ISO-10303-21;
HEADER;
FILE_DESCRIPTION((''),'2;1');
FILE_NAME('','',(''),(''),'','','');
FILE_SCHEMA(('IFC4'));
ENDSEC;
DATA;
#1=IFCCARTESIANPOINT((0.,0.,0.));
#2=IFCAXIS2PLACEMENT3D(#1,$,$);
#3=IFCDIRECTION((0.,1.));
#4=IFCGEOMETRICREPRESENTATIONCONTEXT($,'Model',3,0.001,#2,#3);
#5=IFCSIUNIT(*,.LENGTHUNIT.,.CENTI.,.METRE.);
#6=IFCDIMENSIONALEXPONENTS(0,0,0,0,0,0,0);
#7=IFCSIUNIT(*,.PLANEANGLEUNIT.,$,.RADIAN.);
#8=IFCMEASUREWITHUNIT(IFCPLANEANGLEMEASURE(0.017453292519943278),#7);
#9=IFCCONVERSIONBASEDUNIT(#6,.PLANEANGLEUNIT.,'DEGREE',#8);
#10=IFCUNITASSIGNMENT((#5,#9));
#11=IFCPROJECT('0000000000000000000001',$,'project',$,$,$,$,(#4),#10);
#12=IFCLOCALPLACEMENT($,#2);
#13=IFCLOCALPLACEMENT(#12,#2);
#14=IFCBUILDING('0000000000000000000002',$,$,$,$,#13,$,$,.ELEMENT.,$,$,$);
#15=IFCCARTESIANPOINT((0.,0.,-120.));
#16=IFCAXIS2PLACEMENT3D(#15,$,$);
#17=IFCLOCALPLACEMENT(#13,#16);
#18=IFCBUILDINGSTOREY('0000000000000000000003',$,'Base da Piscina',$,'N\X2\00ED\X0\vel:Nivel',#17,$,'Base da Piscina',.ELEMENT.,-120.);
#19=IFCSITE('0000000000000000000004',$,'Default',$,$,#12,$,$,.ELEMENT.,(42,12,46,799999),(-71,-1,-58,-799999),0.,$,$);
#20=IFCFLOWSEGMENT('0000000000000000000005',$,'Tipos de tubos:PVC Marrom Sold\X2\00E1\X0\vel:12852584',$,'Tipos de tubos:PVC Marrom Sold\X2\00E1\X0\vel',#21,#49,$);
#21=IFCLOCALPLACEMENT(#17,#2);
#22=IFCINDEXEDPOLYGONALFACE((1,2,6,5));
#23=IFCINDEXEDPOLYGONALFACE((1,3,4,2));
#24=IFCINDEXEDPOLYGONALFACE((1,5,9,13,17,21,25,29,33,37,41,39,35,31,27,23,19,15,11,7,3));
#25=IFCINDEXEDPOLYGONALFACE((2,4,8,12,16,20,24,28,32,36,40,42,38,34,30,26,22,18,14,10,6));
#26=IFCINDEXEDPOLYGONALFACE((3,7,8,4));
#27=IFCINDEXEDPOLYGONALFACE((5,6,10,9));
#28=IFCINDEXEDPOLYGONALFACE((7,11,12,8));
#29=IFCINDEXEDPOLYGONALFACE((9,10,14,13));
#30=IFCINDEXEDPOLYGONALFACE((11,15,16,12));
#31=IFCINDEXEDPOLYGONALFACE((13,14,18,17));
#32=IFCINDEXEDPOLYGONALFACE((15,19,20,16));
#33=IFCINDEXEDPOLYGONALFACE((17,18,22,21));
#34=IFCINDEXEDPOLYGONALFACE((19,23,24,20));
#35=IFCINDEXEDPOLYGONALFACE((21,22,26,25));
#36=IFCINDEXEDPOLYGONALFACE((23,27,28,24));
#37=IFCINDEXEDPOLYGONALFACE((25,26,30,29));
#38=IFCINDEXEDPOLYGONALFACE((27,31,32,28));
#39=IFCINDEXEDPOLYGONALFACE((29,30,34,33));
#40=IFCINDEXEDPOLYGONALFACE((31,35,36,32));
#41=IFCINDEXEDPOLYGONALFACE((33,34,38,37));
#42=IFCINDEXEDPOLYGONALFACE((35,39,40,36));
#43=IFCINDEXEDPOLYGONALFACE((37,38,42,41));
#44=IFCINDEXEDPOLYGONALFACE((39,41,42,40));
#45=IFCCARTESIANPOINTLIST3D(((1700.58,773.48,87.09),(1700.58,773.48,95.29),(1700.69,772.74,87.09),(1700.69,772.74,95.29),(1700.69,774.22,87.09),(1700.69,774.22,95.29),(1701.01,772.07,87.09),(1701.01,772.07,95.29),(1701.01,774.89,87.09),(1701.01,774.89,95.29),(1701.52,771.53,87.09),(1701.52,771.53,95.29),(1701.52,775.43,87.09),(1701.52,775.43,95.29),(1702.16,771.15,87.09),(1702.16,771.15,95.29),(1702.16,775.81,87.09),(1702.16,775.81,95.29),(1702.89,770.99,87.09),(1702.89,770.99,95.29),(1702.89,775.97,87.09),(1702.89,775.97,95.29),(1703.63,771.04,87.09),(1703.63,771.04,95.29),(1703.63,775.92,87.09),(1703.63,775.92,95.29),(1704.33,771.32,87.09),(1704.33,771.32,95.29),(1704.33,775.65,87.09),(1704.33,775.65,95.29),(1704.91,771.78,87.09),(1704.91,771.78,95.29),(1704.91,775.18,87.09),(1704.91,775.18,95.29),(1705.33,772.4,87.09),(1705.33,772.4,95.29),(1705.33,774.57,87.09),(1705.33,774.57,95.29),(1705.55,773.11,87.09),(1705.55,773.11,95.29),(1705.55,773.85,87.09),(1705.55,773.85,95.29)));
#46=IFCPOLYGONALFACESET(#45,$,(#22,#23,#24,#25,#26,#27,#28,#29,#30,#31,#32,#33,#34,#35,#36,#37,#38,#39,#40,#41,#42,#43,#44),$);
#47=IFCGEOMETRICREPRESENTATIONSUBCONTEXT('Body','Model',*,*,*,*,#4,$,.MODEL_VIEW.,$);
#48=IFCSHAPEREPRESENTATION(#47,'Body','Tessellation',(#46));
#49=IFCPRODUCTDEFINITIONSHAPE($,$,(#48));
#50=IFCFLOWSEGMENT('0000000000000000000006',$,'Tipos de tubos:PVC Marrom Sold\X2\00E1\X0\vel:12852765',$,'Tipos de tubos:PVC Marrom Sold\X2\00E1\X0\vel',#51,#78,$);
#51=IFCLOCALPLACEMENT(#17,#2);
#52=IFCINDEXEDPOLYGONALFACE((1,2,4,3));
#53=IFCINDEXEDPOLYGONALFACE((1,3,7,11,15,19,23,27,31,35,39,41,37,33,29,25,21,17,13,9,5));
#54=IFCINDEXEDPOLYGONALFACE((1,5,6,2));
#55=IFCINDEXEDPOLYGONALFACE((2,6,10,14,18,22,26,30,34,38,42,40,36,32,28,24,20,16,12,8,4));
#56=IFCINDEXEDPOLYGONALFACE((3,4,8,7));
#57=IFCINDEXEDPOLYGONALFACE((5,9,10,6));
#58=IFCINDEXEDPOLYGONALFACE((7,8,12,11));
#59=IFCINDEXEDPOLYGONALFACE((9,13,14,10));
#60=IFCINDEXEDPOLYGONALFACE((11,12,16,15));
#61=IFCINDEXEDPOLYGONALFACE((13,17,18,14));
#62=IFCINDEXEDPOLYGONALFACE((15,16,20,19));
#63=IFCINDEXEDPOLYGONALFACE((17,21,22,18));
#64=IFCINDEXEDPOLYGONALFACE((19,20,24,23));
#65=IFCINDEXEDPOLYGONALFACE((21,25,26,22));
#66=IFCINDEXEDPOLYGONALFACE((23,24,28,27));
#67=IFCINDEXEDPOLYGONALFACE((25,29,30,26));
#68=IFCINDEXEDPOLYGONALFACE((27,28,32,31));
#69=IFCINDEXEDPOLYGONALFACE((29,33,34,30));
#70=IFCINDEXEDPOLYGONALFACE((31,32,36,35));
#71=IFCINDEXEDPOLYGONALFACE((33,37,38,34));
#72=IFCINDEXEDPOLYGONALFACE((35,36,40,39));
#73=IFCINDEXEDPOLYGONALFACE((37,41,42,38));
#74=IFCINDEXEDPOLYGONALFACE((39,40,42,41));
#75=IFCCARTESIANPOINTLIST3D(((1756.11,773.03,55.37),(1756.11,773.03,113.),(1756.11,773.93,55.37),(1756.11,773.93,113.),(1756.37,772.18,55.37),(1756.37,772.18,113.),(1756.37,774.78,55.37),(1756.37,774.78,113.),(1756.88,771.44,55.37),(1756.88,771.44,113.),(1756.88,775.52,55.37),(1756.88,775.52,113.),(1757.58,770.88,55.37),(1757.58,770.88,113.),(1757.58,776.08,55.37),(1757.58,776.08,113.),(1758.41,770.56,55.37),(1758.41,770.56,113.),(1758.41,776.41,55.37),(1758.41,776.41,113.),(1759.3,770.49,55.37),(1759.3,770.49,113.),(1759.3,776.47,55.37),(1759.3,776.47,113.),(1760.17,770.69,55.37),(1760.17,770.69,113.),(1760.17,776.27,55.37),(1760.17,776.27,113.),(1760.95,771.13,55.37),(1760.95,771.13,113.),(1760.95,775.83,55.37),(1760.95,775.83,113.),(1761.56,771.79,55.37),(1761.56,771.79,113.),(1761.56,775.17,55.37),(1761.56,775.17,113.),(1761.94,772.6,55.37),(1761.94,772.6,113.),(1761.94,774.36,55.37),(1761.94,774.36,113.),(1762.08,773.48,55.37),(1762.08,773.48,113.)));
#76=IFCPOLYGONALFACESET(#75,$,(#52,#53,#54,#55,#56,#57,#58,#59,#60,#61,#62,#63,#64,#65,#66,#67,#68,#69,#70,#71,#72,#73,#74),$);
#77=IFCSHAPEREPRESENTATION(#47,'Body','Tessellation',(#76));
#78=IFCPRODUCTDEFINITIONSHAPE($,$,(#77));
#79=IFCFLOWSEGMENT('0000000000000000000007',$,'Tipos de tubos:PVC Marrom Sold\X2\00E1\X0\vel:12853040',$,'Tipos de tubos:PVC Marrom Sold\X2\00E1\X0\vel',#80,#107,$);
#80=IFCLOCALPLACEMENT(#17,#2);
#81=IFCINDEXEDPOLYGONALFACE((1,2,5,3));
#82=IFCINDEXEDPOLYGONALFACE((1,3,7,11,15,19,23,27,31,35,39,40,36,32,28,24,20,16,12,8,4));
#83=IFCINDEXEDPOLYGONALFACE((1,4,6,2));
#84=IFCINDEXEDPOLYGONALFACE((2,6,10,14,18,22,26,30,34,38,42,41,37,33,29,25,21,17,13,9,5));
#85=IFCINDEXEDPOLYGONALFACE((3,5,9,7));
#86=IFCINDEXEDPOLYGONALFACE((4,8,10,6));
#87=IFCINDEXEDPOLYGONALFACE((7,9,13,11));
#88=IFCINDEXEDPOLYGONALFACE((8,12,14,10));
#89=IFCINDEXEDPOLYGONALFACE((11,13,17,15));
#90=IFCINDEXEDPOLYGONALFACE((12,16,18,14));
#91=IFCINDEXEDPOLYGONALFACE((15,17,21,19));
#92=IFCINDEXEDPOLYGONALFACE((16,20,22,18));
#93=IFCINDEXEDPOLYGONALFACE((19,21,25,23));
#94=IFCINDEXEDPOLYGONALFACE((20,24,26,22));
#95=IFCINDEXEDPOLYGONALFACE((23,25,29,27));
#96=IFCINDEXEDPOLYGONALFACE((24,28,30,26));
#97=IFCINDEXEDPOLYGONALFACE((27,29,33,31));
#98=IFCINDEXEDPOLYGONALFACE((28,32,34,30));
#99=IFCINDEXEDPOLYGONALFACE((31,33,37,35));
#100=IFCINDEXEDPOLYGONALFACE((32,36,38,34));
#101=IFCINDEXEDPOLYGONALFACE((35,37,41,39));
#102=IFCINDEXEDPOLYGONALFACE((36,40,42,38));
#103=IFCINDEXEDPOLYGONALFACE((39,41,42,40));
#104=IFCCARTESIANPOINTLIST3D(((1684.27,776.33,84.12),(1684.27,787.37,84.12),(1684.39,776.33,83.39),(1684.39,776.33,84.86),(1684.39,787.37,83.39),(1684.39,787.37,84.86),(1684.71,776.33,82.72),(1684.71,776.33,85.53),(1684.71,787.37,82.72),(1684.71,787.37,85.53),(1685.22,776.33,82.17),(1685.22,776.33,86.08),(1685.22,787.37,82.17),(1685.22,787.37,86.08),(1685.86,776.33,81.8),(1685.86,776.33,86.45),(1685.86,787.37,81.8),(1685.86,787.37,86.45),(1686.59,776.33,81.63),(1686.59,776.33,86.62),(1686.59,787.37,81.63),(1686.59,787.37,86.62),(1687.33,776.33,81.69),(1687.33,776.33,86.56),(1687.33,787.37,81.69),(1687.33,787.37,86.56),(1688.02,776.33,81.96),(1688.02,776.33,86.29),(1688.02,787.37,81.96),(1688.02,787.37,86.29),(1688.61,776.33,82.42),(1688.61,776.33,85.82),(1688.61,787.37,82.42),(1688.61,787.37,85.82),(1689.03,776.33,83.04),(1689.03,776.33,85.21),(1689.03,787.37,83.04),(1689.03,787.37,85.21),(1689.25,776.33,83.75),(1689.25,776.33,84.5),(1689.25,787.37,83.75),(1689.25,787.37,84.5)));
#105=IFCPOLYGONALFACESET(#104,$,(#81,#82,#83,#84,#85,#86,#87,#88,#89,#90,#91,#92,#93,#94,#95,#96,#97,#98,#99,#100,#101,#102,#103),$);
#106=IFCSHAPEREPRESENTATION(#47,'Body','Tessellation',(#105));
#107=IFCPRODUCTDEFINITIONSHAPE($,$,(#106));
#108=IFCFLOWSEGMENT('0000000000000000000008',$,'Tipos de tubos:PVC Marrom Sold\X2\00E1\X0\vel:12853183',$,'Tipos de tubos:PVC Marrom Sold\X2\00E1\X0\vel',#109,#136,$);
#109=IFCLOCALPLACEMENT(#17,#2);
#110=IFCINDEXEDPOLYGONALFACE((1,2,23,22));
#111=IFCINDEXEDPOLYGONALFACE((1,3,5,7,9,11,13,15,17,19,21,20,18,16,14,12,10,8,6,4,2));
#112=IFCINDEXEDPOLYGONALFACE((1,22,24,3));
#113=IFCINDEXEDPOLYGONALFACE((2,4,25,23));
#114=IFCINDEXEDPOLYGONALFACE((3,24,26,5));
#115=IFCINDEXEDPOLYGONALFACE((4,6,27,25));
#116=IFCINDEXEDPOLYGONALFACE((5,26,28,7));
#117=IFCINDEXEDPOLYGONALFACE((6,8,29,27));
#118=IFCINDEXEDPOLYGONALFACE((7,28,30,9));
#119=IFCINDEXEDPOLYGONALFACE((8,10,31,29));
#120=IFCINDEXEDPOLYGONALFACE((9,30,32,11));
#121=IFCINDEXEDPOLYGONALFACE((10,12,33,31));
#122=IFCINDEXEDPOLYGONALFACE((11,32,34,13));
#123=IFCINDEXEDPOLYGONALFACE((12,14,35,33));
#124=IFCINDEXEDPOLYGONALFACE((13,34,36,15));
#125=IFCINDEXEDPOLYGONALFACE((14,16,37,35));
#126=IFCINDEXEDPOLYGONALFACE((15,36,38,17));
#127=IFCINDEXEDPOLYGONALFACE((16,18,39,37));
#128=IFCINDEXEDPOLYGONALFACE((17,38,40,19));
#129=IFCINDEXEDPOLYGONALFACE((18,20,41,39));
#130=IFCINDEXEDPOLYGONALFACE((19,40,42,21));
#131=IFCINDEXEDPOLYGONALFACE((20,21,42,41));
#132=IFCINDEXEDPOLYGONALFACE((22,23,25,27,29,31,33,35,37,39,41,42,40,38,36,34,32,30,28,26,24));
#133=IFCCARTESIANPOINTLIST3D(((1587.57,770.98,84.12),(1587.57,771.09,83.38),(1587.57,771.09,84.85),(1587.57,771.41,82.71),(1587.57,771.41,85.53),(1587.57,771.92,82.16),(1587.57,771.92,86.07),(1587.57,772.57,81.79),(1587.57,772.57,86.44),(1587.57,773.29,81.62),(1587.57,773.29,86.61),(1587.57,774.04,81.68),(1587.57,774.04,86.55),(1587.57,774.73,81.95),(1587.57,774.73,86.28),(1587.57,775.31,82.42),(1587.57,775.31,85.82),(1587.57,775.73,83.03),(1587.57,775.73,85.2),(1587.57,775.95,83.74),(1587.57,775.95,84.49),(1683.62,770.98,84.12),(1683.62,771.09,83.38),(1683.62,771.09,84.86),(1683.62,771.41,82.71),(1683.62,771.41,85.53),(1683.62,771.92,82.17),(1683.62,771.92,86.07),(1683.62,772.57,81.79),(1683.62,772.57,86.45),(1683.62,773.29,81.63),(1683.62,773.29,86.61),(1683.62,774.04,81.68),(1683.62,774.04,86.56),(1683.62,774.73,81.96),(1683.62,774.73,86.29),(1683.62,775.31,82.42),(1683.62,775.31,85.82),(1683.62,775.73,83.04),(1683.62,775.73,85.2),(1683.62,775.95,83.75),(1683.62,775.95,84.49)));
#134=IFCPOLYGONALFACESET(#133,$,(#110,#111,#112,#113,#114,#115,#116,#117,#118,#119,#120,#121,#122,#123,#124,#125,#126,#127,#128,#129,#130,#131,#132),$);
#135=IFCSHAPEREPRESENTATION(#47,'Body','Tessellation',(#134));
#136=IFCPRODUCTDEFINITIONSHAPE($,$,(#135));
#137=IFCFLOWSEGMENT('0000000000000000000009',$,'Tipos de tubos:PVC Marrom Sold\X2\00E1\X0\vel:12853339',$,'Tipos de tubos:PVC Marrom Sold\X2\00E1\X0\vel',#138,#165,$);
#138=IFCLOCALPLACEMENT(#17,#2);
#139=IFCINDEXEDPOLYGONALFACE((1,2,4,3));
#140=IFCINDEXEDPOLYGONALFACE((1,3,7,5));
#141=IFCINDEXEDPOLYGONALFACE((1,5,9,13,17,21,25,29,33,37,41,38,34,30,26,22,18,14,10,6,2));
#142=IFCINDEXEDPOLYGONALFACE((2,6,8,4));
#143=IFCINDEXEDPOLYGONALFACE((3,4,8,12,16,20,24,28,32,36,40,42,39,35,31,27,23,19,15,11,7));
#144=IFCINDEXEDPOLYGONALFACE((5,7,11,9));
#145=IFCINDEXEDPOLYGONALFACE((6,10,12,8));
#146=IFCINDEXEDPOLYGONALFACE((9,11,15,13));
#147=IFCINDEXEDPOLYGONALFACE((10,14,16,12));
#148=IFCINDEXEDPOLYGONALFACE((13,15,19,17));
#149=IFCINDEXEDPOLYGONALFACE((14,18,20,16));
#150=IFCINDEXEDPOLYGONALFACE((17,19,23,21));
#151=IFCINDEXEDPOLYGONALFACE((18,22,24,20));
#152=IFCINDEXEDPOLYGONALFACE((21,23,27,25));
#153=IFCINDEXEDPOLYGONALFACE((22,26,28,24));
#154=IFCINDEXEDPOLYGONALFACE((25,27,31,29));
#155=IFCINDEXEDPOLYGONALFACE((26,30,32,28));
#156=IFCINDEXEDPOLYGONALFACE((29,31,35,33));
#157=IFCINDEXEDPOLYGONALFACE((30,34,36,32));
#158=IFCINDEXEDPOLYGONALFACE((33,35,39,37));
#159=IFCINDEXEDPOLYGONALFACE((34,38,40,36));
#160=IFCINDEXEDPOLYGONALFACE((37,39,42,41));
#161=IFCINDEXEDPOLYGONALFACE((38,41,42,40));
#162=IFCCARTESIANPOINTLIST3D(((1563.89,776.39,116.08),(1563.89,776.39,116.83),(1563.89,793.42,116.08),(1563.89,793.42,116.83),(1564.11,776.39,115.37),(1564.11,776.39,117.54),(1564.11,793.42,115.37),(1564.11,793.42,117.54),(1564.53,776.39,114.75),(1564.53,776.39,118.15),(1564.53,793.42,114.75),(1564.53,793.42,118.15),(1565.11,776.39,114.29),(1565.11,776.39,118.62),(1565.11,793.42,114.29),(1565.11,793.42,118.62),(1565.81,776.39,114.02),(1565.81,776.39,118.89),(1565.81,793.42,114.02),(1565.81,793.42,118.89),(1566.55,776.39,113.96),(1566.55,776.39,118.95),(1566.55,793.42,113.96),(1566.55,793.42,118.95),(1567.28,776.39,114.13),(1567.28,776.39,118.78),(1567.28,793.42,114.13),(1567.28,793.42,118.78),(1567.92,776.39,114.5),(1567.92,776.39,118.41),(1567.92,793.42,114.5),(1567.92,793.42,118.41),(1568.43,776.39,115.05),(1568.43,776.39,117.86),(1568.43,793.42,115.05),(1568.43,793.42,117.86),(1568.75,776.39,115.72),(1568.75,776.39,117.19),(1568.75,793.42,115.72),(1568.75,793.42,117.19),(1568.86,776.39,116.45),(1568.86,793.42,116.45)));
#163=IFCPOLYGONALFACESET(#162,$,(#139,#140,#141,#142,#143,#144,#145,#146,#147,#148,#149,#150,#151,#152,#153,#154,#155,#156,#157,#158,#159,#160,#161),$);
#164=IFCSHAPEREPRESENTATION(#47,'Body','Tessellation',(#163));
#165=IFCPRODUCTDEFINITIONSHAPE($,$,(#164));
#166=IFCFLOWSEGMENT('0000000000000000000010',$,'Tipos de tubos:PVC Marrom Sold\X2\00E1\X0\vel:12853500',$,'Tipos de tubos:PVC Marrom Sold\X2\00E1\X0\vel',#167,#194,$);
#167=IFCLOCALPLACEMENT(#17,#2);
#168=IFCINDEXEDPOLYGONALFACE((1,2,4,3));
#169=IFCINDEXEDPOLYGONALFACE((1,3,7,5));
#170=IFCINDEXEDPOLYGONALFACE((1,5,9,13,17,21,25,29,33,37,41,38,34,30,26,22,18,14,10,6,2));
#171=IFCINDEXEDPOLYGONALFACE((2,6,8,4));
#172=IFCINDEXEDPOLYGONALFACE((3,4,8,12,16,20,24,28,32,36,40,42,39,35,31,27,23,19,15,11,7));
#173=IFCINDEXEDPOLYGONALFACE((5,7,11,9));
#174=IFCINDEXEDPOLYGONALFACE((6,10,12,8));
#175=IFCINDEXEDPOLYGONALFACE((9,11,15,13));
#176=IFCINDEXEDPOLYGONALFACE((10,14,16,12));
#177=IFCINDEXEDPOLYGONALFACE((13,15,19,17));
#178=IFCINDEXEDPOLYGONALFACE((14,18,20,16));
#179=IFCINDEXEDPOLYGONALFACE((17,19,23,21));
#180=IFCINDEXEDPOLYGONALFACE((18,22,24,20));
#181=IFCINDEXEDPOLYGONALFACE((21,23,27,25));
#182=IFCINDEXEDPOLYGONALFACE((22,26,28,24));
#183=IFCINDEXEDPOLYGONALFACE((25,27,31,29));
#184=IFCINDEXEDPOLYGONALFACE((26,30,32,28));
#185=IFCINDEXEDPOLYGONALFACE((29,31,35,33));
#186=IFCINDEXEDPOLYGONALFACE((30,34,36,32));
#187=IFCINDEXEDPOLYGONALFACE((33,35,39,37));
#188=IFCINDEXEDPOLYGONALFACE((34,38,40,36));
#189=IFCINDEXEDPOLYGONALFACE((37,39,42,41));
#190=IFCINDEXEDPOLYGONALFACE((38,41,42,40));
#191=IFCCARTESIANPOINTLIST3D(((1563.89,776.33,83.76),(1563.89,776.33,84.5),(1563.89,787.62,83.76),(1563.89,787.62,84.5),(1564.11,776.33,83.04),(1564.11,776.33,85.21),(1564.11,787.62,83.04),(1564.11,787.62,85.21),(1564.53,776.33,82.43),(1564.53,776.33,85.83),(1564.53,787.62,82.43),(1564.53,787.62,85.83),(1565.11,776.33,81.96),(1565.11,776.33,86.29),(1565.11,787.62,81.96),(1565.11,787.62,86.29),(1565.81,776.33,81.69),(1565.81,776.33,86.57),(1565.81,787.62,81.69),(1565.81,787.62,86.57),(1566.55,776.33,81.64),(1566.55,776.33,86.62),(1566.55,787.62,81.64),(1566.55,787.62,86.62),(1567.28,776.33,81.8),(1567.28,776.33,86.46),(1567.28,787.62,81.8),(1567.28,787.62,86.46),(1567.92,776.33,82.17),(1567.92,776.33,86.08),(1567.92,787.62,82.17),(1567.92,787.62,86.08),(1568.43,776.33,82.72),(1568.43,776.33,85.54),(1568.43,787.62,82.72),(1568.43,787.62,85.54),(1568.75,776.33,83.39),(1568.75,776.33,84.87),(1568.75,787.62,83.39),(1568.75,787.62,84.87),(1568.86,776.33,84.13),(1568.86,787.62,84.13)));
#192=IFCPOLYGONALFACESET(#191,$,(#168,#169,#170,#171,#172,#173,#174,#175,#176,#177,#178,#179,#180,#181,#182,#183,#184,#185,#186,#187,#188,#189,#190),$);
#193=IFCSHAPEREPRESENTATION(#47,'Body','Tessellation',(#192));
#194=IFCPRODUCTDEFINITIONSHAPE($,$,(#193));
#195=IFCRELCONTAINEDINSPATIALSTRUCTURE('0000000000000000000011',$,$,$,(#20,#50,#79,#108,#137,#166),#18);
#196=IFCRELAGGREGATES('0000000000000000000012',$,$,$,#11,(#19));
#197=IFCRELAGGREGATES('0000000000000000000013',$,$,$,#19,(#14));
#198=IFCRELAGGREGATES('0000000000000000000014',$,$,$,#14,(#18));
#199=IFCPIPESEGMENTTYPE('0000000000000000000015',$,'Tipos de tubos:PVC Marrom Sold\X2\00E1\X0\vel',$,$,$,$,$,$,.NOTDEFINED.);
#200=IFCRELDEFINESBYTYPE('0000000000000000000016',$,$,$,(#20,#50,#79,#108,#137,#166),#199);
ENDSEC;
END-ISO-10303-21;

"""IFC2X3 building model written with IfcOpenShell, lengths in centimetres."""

from ifc_helpers import new_model, entity, si_unit, converted_unit, direction, frame, frame_2d, origin, origin_2d_with_axis, place, context, subcontext, project, spatial, circle, extrude, type_object, element, save


model = new_model("IFC2X3")

# Units and contexts
model_context = context("Model", 3, precision=0.001, world=origin(), true_north=direction((0.0, 1.0)))
body_context = subcontext(model_context, "Body", "Model", "MODEL_VIEW")
ifc_project = project(units=[si_unit("LENGTHUNIT", "METRE", prefix="CENTI"), converted_unit("PLANEANGLEUNIT", "DEGREE", entity("IfcPlaneAngleMeasure", 0.017453292519943278), si_unit("PLANEANGLEUNIT", "RADIAN"), dimensions=[0, 0, 0, 0, 0, 0, 0])], contexts=[model_context])

# Site, building, storey
site_placement = place(None, origin())
site = spatial("IfcSite", under=ifc_project, at=site_placement, Name="Default", CompositionType="ELEMENT", RefLatitude=(42, 12, 46, 799999), RefLongitude=(-71, -1, -58, -799999), RefElevation=0.0)
building_placement = place(site_placement, origin())
building = spatial("IfcBuilding", under=site, at=building_placement, CompositionType="ELEMENT")
storey_placement = place(building_placement, frame((0.0, 0.0, -120.0)))
storey = spatial("IfcBuildingStorey", under=building, at=storey_placement, Name="Base da Piscina", ObjectType="Nível:Nivel", LongName="Base da Piscina", CompositionType="ELEMENT", Elevation=-120.0)

# Flow segments
pipe_segment_type = type_object("IfcPipeSegmentType", Name="Tipos de tubos:PVC Marrom Soldável", PredefinedType="NOTDEFINED")
flow_segment_1_placement = place(storey_placement, origin())
element("IfcFlowSegment", 1, at=flow_segment_1_placement, inside=storey, type_object=pipe_segment_type, Name="Tipos de tubos:PVC Marrom Soldável:12852584", ObjectType="Tipos de tubos:PVC Marrom Soldável", context=body_context, shape_type="SweptSolid", body=[
    extrude(circle(Radius=2.5, at=frame_2d((0.0, 0.0), x_axis=(1.0, 0.0))), frame((1703.08, 773.48, 87.09), z_axis=(0.0, 0.0, 1.0), x_axis=(-1.0, 0.0, 0.0)), (0.0, 0.0, 1.0), 8.21),
])
flow_segment_2_placement = place(storey_placement, origin())
element("IfcFlowSegment", 2, at=flow_segment_2_placement, inside=storey, type_object=pipe_segment_type, Name="Tipos de tubos:PVC Marrom Soldável:12852765", ObjectType="Tipos de tubos:PVC Marrom Soldável", context=body_context, shape_type="SweptSolid", body=[
    extrude(circle(Radius=3.0, at=origin_2d_with_axis()), frame((1759.08, 773.48, 55.37)), (0.0, 0.0, 1.0), 57.63),
])
flow_segment_3_placement = place(storey_placement, origin())
element("IfcFlowSegment", 3, at=flow_segment_3_placement, inside=storey, type_object=pipe_segment_type, Name="Tipos de tubos:PVC Marrom Soldável:12853040", ObjectType="Tipos de tubos:PVC Marrom Soldável", context=body_context, shape_type="SweptSolid", body=[
    extrude(circle(Radius=2.5, at=origin_2d_with_axis()), frame((1686.77, 776.33, 84.12), z_axis=(0.0, 1.0, 0.0), x_axis=(-1.0, 0.0, 0.0)), (0.0, 0.0, 1.0), 11.04),
])
flow_segment_4_placement = place(storey_placement, origin())
element("IfcFlowSegment", 4, at=flow_segment_4_placement, inside=storey, type_object=pipe_segment_type, Name="Tipos de tubos:PVC Marrom Soldável:12853183", ObjectType="Tipos de tubos:PVC Marrom Soldável", context=body_context, shape_type="SweptSolid", body=[
    extrude(circle(Radius=2.5, at=frame_2d((0.0, 0.0), x_axis=(1.0, 0.0))), frame((1587.57, 773.48, 84.12), z_axis=(1.0, 0.0, 0.000035), x_axis=(0.0, -1.0, 0.0)), (0.0, 0.0, 1.0), 96.06),
])
flow_segment_5_placement = place(storey_placement, origin())
element("IfcFlowSegment", 5, at=flow_segment_5_placement, inside=storey, type_object=pipe_segment_type, Name="Tipos de tubos:PVC Marrom Soldável:12853339", ObjectType="Tipos de tubos:PVC Marrom Soldável", context=body_context, shape_type="SweptSolid", body=[
    extrude(circle(Radius=2.5, at=frame_2d((0.0, 0.0), x_axis=(1.0, 0.0))), frame((1566.36, 776.39, 116.45), z_axis=(0.0, 1.0, 0.0), x_axis=(1.0, 0.0, 0.0)), (0.0, 0.0, 1.0), 17.03),
])
flow_segment_6_placement = place(storey_placement, origin())
element("IfcFlowSegment", 6, at=flow_segment_6_placement, inside=storey, type_object=pipe_segment_type, Name="Tipos de tubos:PVC Marrom Soldável:12853500", ObjectType="Tipos de tubos:PVC Marrom Soldável", context=body_context, shape_type="SweptSolid", body=[
    extrude(circle(Radius=2.5, at=origin_2d_with_axis()), frame((1566.36, 776.33, 84.13), z_axis=(0.0, 1.0, 0.0), x_axis=(1.0, 0.0, 0.0)), (0.0, 0.0, 1.0), 11.29),
])

save(model, "model.ifc")
